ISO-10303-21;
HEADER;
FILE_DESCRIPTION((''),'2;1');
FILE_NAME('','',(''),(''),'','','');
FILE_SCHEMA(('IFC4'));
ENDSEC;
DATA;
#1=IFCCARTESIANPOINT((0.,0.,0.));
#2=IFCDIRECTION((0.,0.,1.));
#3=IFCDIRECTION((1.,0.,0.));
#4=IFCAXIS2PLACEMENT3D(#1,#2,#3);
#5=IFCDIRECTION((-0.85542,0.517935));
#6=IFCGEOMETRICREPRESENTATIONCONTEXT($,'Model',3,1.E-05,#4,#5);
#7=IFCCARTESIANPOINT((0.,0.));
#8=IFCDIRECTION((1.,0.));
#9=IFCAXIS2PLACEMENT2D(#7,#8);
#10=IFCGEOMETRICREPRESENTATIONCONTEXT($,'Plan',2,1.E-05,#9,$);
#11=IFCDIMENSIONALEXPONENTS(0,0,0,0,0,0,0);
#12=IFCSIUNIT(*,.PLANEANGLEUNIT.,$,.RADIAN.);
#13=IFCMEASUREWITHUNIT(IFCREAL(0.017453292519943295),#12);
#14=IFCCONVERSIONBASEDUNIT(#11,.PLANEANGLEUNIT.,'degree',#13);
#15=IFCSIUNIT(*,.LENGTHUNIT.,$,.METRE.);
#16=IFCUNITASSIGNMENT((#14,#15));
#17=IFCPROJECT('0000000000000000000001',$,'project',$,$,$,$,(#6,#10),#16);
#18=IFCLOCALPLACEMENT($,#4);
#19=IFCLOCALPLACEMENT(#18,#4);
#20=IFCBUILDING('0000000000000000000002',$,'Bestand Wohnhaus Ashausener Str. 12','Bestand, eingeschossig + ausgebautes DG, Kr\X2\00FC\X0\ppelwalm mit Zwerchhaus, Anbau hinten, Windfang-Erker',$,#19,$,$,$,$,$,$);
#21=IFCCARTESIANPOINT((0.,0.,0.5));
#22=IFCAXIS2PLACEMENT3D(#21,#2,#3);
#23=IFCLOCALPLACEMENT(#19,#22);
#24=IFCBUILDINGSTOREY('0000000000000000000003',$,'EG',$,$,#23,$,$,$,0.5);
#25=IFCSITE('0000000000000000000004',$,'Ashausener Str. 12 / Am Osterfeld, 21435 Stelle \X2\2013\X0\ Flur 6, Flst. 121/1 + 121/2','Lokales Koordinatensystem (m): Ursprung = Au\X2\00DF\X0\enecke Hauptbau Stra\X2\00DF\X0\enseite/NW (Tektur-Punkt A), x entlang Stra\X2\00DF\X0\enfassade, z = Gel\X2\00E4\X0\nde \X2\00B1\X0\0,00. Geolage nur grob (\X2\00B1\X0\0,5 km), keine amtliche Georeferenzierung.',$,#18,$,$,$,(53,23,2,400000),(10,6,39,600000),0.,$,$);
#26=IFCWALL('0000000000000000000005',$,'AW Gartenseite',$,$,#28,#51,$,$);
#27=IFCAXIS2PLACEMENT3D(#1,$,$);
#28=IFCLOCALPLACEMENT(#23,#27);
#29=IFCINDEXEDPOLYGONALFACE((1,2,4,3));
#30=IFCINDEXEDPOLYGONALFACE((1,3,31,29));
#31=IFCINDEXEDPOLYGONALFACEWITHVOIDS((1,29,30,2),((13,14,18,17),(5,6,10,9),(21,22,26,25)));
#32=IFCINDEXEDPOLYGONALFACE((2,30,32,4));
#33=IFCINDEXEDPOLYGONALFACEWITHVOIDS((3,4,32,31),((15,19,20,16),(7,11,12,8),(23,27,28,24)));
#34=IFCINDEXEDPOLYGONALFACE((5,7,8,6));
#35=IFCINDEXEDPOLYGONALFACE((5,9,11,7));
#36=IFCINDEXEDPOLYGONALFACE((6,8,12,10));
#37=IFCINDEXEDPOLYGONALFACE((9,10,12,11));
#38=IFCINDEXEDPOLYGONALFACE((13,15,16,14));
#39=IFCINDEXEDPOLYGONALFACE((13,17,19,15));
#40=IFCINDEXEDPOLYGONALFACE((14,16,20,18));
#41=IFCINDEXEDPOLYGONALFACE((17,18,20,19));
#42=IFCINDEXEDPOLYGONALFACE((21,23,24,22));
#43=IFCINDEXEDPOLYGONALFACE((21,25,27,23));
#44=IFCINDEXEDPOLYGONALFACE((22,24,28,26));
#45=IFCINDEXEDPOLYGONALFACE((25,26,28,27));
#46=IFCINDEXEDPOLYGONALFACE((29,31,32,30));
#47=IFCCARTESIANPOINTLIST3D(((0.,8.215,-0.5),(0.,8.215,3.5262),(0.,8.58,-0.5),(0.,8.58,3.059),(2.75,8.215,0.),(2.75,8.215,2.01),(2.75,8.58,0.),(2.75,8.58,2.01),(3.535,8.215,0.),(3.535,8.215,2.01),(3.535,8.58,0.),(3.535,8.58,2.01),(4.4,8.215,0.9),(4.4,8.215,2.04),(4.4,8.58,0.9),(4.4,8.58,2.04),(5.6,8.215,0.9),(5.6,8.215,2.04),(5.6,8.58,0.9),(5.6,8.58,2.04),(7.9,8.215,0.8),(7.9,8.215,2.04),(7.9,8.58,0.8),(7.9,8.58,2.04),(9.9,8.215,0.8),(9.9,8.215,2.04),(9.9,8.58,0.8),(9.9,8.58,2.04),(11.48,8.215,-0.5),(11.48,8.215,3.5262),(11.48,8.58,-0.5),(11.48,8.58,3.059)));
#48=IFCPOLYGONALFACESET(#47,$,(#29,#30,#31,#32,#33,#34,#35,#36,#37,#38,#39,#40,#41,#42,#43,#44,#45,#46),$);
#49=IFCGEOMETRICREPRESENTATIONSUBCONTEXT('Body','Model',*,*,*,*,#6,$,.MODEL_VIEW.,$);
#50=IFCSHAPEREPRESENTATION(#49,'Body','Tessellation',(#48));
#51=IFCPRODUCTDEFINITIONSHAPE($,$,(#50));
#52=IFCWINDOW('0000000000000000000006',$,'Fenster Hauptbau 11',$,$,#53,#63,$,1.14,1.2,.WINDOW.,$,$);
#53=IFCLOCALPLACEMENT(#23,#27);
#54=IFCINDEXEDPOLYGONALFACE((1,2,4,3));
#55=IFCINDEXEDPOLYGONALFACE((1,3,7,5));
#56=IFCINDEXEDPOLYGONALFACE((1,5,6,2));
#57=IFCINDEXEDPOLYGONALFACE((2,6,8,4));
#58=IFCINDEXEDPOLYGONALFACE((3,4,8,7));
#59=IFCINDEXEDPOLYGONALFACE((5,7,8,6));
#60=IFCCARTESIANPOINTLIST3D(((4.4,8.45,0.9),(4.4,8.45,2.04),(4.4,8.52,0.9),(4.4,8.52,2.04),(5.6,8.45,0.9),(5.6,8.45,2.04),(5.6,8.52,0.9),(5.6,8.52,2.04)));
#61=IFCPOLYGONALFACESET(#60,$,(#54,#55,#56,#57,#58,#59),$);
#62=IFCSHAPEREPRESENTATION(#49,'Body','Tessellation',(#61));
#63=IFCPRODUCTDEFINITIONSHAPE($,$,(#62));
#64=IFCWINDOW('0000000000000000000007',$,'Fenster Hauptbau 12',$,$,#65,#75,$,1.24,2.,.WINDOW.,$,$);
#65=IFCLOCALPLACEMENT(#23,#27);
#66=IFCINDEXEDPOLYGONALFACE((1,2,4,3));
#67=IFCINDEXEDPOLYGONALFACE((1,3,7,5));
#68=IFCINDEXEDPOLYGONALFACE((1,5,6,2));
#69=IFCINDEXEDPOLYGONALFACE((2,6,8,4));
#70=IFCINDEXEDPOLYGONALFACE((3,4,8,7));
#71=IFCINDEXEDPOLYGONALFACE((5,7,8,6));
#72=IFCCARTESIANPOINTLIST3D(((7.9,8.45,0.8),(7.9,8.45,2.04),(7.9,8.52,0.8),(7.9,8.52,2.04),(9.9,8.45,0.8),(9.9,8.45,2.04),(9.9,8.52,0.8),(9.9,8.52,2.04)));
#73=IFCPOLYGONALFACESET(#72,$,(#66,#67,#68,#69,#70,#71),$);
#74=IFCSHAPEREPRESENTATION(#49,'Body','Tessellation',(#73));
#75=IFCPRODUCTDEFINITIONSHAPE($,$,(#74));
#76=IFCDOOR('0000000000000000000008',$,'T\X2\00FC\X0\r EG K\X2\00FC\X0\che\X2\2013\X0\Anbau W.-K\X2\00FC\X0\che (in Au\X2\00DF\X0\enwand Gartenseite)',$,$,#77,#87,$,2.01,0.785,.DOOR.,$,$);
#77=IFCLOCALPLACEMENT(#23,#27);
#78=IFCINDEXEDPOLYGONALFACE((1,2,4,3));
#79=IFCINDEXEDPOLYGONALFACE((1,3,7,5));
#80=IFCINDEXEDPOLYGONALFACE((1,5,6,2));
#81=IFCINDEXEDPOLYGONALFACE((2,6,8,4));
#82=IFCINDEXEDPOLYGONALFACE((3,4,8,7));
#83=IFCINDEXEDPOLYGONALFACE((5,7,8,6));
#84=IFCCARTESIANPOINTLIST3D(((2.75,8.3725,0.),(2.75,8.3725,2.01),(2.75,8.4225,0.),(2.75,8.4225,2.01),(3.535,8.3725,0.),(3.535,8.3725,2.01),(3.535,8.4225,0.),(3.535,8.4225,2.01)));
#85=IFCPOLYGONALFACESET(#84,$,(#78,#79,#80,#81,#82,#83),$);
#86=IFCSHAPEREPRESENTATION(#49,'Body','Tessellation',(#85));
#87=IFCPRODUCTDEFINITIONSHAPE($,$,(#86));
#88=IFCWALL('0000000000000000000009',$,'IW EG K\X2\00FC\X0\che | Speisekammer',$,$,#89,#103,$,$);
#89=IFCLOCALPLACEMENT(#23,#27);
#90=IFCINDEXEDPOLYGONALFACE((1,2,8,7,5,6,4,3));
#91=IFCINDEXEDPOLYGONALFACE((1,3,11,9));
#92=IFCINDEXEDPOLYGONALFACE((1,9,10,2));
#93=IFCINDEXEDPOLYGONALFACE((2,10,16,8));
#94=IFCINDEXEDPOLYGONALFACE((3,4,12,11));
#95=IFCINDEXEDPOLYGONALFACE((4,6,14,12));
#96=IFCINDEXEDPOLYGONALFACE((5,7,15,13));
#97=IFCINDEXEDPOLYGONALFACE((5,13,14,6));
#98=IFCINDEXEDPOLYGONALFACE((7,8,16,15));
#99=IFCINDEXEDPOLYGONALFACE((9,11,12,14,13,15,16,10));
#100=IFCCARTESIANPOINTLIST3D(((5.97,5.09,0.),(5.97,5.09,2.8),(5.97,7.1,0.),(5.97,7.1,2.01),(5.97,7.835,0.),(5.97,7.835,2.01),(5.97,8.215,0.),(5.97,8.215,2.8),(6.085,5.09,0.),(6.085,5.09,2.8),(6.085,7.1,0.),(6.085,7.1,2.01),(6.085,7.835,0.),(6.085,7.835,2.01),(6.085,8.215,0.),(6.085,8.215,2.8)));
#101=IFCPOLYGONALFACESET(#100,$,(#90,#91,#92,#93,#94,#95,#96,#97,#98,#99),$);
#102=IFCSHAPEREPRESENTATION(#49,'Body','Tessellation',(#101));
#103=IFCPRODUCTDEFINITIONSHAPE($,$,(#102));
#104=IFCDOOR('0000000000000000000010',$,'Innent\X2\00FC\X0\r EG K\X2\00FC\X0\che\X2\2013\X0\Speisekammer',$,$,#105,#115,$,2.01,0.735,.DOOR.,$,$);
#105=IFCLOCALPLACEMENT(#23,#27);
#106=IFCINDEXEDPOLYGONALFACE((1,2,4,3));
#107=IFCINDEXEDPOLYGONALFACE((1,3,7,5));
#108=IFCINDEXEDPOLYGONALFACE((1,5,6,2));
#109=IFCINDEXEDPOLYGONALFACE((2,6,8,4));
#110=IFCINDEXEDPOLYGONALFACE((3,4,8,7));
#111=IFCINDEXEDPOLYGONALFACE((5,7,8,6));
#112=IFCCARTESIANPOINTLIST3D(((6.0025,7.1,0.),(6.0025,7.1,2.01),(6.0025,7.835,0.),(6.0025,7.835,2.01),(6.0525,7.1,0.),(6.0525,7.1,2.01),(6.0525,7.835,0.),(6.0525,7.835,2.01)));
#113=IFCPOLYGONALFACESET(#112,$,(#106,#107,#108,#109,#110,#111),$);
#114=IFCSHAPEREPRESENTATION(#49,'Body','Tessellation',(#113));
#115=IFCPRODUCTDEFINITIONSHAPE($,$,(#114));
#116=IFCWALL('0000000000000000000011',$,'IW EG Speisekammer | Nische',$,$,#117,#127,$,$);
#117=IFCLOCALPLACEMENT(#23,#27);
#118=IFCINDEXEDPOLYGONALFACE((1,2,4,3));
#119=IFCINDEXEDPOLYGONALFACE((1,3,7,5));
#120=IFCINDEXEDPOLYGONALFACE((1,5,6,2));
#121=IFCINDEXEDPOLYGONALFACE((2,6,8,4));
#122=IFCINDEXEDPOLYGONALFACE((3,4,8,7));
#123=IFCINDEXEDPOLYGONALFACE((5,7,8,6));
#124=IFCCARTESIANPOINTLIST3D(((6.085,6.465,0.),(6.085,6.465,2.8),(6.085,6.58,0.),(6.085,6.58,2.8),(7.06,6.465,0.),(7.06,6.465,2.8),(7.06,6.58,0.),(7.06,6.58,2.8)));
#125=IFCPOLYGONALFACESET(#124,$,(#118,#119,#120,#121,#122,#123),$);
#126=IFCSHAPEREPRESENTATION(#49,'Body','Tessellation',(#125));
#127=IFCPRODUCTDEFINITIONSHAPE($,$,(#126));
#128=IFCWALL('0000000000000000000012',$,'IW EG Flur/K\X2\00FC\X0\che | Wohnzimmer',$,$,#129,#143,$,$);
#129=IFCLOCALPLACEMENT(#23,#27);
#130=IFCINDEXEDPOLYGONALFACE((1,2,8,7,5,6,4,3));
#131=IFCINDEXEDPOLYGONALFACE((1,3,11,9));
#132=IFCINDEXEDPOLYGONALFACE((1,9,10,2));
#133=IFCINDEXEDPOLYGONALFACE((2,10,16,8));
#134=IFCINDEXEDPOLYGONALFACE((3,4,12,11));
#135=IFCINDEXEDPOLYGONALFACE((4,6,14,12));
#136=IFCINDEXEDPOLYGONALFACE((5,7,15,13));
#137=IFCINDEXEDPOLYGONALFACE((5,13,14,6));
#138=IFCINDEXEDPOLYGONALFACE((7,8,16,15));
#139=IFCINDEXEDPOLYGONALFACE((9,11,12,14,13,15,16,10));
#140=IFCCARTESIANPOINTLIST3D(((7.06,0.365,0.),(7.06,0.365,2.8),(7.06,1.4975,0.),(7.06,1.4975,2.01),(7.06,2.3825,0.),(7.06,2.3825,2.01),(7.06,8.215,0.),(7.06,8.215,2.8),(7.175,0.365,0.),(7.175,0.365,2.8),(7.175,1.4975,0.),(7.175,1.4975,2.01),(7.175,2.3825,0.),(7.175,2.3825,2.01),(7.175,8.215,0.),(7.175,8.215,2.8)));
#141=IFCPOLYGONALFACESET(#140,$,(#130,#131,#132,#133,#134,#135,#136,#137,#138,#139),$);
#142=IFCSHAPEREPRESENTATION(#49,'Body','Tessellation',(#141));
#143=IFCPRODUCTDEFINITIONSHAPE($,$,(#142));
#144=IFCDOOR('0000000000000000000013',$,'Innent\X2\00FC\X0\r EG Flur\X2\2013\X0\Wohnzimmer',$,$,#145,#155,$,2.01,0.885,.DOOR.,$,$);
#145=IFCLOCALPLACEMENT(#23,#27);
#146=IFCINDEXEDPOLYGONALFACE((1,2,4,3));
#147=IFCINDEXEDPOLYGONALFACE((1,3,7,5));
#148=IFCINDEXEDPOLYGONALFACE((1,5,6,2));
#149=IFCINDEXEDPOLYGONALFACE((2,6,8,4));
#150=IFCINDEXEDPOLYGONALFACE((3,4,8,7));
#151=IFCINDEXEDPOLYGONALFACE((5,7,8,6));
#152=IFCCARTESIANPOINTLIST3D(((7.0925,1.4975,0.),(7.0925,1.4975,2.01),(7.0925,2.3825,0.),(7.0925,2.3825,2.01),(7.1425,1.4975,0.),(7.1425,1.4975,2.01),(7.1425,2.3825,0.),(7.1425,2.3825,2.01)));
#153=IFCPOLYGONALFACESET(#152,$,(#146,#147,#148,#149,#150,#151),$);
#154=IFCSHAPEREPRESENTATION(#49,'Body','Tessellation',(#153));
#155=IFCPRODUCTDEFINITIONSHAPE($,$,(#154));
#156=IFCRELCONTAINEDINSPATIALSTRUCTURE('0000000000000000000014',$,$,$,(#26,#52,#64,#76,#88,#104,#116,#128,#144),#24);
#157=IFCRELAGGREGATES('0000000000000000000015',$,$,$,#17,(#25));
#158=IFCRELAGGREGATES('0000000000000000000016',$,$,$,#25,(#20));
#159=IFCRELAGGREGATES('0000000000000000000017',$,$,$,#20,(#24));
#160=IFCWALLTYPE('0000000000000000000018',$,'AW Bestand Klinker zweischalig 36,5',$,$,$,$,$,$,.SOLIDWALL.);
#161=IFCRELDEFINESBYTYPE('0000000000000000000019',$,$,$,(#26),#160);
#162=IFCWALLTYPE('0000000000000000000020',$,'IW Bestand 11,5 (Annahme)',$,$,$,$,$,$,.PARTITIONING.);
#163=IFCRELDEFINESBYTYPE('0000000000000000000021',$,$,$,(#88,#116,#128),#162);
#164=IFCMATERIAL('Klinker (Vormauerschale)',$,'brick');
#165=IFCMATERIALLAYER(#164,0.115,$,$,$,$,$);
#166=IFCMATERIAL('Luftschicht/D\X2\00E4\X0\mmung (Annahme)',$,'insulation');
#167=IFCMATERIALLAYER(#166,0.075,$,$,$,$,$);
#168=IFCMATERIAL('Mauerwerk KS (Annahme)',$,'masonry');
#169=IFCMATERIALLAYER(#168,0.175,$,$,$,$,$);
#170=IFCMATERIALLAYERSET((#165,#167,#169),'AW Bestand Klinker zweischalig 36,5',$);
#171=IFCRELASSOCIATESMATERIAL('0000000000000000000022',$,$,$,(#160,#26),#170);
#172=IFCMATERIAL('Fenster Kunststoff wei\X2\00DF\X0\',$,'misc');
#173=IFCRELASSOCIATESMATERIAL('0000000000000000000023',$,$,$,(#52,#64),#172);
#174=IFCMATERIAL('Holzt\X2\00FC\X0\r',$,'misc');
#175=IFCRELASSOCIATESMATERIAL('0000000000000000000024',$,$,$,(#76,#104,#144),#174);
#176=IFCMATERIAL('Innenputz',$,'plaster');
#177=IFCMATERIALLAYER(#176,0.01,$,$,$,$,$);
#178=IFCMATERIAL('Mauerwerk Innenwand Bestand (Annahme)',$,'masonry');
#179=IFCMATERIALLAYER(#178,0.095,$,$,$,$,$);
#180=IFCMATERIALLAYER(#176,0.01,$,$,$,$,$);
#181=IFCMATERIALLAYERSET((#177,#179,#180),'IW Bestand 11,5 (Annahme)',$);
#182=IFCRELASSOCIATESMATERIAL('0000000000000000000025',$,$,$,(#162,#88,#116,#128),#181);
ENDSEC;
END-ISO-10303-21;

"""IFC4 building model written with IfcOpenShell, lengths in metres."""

from ifc_helpers import new_model, entity, si_unit, converted_unit, direction, frame, origin_with_axes, origin_2d_with_axis, place, context, subcontext, project, spatial, indexed_curve, outline, extrude, clip, halfspace, material, layer, layer_set, layer_usage, type_object, element, fill, save


model = new_model("IFC4")

# Units and contexts
model_context = context("Model", 3, precision=1e-05, world=origin_with_axes(), true_north=direction((-0.85542, 0.517935)))
plan_context = context("Plan", 2, precision=1e-05, world=origin_2d_with_axis())
body_context = subcontext(model_context, "Body", "Model", "MODEL_VIEW")
ifc_project = project(units=[converted_unit("PLANEANGLEUNIT", "degree", entity("IfcReal", 0.017453292519943295), si_unit("PLANEANGLEUNIT", "RADIAN"), dimensions=[0, 0, 0, 0, 0, 0, 0]), si_unit("LENGTHUNIT", "METRE")], contexts=[model_context, plan_context])

# Site, building, storey
site_placement = place(None, origin_with_axes())
site = spatial("IfcSite", under=ifc_project, at=site_placement, Name="Ashausener Str. 12 / Am Osterfeld, 21435 Stelle – Flur 6, Flst. 121/1 + 121/2", Description="Lokales Koordinatensystem (m): Ursprung = Außenecke Hauptbau Straßenseite/NW (Tektur-Punkt A), x entlang Straßenfassade, z = Gelände ±0,00. Geolage nur grob (±0,5 km), keine amtliche Georeferenzierung.", RefLatitude=(53, 23, 2, 400000), RefLongitude=(10, 6, 39, 600000), RefElevation=0.0)
building_placement = place(site_placement, origin_with_axes())
building = spatial("IfcBuilding", under=site, at=building_placement, Name="Bestand Wohnhaus Ashausener Str. 12", Description="Bestand, eingeschossig + ausgebautes DG, Krüppelwalm mit Zwerchhaus, Anbau hinten, Windfang-Erker")
storey_placement = place(building_placement, frame((0.0, 0.0, 0.5), z_axis=(0.0, 0.0, 1.0), x_axis=(1.0, 0.0, 0.0)))
storey = spatial("IfcBuildingStorey", under=building, at=storey_placement, Name="EG", Elevation=0.5)

# Wall, openings, windows, door
ifc_material_1 = material(Name="Klinker (Vormauerschale)", Category="brick")
ifc_layer_1 = layer(ifc_material_1, 0.115)
ifc_material_2 = material(Name="Luftschicht/Dämmung (Annahme)", Category="insulation")
ifc_layer_2 = layer(ifc_material_2, 0.075)
ifc_material_3 = material(Name="Mauerwerk KS (Annahme)", Category="masonry")
ifc_layer_3 = layer(ifc_material_3, 0.175)
ifc_layer_set_1 = layer_set([ifc_layer_1, ifc_layer_2, ifc_layer_3], Name="AW Bestand Klinker zweischalig 36,5")
ifc_layer_usage_1 = layer_usage(ifc_layer_set_1, "AXIS2", "POSITIVE", 0.0)
wall_type_1 = type_object("IfcWallType", Name="AW Bestand Klinker zweischalig 36,5", PredefinedType="SOLIDWALL", material=ifc_layer_set_1)
wall_1_placement = place(storey_placement, frame((11.48, 8.58, -0.5), z_axis=(0.0, 0.0, 1.0), x_axis=(-1.0, 0.0, 0.0)))
wall_1 = element("IfcWall", 1, at=wall_1_placement, inside=storey, type_object=wall_type_1, material=ifc_layer_usage_1, Name="AW Gartenseite", context=body_context, shape_type="Clipping", body=[
    clip(clip(clip(clip(extrude(outline(indexed_curve([(0.0, 0.0), (0.0, 0.365), (11.48, 0.365), (11.48, 0.0), (0.0, 0.0)], self_intersect=False)), origin_with_axes(), (0.0, 0.0, 1.0), 12.0), halfspace(frame((-0.39, 8.58, 5.9), z_axis=(-0.76604, 0.0, 0.64279), x_axis=(0.0, 1.0, 0.0)), False)), halfspace(frame((11.87, 8.58, 5.9), z_axis=(0.76604, 0.0, 0.64279), x_axis=(0.0, -1.0, 0.0)), False)), halfspace(frame((11.48, 4.29, 9.05), z_axis=(0.0, -0.78801, 0.61566), x_axis=(-1.0, 0.0, 0.0)), False)), halfspace(frame((11.48, 4.29, 9.05), z_axis=(0.0, 0.78801, 0.61566), x_axis=(1.0, 0.0, 0.0)), False)),
])
opening_1_placement = place(wall_1_placement, frame((5.88, -0.1, 1.4), z_axis=(0.0, 0.0, 1.0), x_axis=(1.0, 0.0, 0.0)))
opening_1 = element("IfcOpeningElement", 2, at=opening_1_placement, cuts=wall_1, context=body_context, shape_type="SweptSolid", body=[
    extrude(outline(indexed_curve([(0.0, 0.0), (0.0, 0.565), (1.2, 0.565), (1.2, 0.0), (0.0, 0.0)], self_intersect=False)), origin_with_axes(), (0.0, 0.0, 1.0), 1.14),
])
opening_2_placement = place(wall_1_placement, frame((1.58, -0.1, 1.3), z_axis=(0.0, 0.0, 1.0), x_axis=(1.0, 0.0, 0.0)))
opening_2 = element("IfcOpeningElement", 3, at=opening_2_placement, cuts=wall_1, context=body_context, shape_type="SweptSolid", body=[
    extrude(outline(indexed_curve([(0.0, 0.0), (0.0, 0.565), (2.0, 0.565), (2.0, 0.0), (0.0, 0.0)], self_intersect=False)), origin_with_axes(), (0.0, 0.0, 1.0), 1.24),
])
opening_3_placement = place(wall_1_placement, frame((7.945, -0.1, 0.5), z_axis=(0.0, 0.0, 1.0), x_axis=(1.0, 0.0, 0.0)))
opening_3 = element("IfcOpeningElement", 4, at=opening_3_placement, cuts=wall_1, context=body_context, shape_type="SweptSolid", body=[
    extrude(outline(indexed_curve([(0.0, 0.0), (0.0, 0.565), (0.785, 0.565), (0.785, 0.0), (0.0, 0.0)], self_intersect=False)), origin_with_axes(), (0.0, 0.0, 1.0), 2.01),
])
ifc_material_4 = material(Name="Fenster Kunststoff weiß", Category="misc")
window_1_placement = place(storey_placement, frame((5.6, 8.52, 0.9), z_axis=(0.0, 0.0, 1.0), x_axis=(-1.0, 0.0, 0.0)))
window_1 = element("IfcWindow", 5, at=window_1_placement, inside=storey, material=ifc_material_4, Name="Fenster Hauptbau 11", OverallHeight=1.14, OverallWidth=1.2, PredefinedType="WINDOW", context=body_context, shape_type="SweptSolid", body=[
    extrude(outline(indexed_curve([(0.0, 0.0), (0.0, 0.07), (1.2, 0.07), (1.2, 0.0), (0.0, 0.0)], self_intersect=False)), origin_with_axes(), (0.0, 0.0, 1.0), 1.14),
])
fill(opening_1, window_1)
window_2_placement = place(storey_placement, frame((9.9, 8.52, 0.8), z_axis=(0.0, 0.0, 1.0), x_axis=(-1.0, 0.0, 0.0)))
window_2 = element("IfcWindow", 6, at=window_2_placement, inside=storey, material=ifc_material_4, Name="Fenster Hauptbau 12", OverallHeight=1.24, OverallWidth=2.0, PredefinedType="WINDOW", context=body_context, shape_type="SweptSolid", body=[
    extrude(outline(indexed_curve([(0.0, 0.0), (0.0, 0.07), (2.0, 0.07), (2.0, 0.0), (0.0, 0.0)], self_intersect=False)), origin_with_axes(), (0.0, 0.0, 1.0), 1.24),
])
fill(opening_2, window_2)
ifc_material_5 = material(Name="Holztür", Category="misc")
door_1_placement = place(storey_placement, frame((3.535, 8.4225, 0.0), z_axis=(0.0, 0.0, 1.0), x_axis=(-1.0, 0.0, 0.0)))
door_1 = element("IfcDoor", 7, at=door_1_placement, inside=storey, material=ifc_material_5, Name="Tür EG Küche–Anbau W.-Küche (in Außenwand Gartenseite)", OverallHeight=2.01, OverallWidth=0.785, PredefinedType="DOOR", context=body_context, shape_type="SweptSolid", body=[
    extrude(outline(indexed_curve([(0.0, 0.0), (0.0, 0.05), (0.785, 0.05), (0.785, 0.0), (0.0, 0.0)], self_intersect=False)), origin_with_axes(), (0.0, 0.0, 1.0), 2.01),
])
fill(opening_3, door_1)

# Wall, opening, door
ifc_material_6 = material(Name="Innenputz", Category="plaster")
ifc_layer_4 = layer(ifc_material_6, 0.01)
ifc_material_7 = material(Name="Mauerwerk Innenwand Bestand (Annahme)", Category="masonry")
ifc_layer_5 = layer(ifc_material_7, 0.095)
ifc_layer_6 = layer(ifc_material_6, 0.01)
ifc_layer_set_2 = layer_set([ifc_layer_4, ifc_layer_5, ifc_layer_6], Name="IW Bestand 11,5 (Annahme)")
ifc_layer_usage_2 = layer_usage(ifc_layer_set_2, "AXIS2", "POSITIVE", 0.0)
wall_type_2 = type_object("IfcWallType", Name="IW Bestand 11,5 (Annahme)", PredefinedType="PARTITIONING", material=ifc_layer_set_2)
wall_2_placement = place(storey_placement, frame((5.97, 8.215, 0.0), z_axis=(0.0, 0.0, 1.0), x_axis=(0.0, -1.0, 0.0)))
wall_2 = element("IfcWall", 8, at=wall_2_placement, inside=storey, type_object=wall_type_2, material=ifc_layer_usage_2, Name="IW EG Küche | Speisekammer", context=body_context, shape_type="SweptSolid", body=[
    extrude(outline(indexed_curve([(0.0, 0.0), (0.0, 0.115), (3.125, 0.115), (3.125, 0.0), (0.0, 0.0)], self_intersect=False)), origin_with_axes(), (0.0, 0.0, 1.0), 2.8),
])
opening_4_placement = place(wall_2_placement, frame((0.38, -0.1, 0.0), z_axis=(0.0, 0.0, 1.0), x_axis=(1.0, 0.0, 0.0)))
opening_4 = element("IfcOpeningElement", 9, at=opening_4_placement, cuts=wall_2, context=body_context, shape_type="SweptSolid", body=[
    extrude(outline(indexed_curve([(0.0, 0.0), (0.0, 0.315), (0.735, 0.315), (0.735, 0.0), (0.0, 0.0)], self_intersect=False)), origin_with_axes(), (0.0, 0.0, 1.0), 2.01),
])
door_2_placement = place(storey_placement, frame((6.0025, 7.835, 0.0), z_axis=(0.0, 0.0, 1.0), x_axis=(0.0, -1.0, 0.0)))
door_2 = element("IfcDoor", 10, at=door_2_placement, inside=storey, material=ifc_material_5, Name="Innentür EG Küche–Speisekammer", OverallHeight=2.01, OverallWidth=0.735, PredefinedType="DOOR", context=body_context, shape_type="SweptSolid", body=[
    extrude(outline(indexed_curve([(0.0, 0.0), (0.0, 0.05), (0.735, 0.05), (0.735, 0.0), (0.0, 0.0)], self_intersect=False)), origin_with_axes(), (0.0, 0.0, 1.0), 2.01),
])
fill(opening_4, door_2)

# Wall
ifc_layer_usage_3 = layer_usage(ifc_layer_set_2, "AXIS2", "POSITIVE", 0.0)
wall_3_placement = place(storey_placement, frame((6.085, 6.465, 0.0), z_axis=(0.0, 0.0, 1.0), x_axis=(1.0, 0.0, 0.0)))
element("IfcWall", 11, at=wall_3_placement, inside=storey, type_object=wall_type_2, material=ifc_layer_usage_3, Name="IW EG Speisekammer | Nische", context=body_context, shape_type="SweptSolid", body=[
    extrude(outline(indexed_curve([(0.0, 0.0), (0.0, 0.115), (0.975, 0.115), (0.975, 0.0), (0.0, 0.0)], self_intersect=False)), origin_with_axes(), (0.0, 0.0, 1.0), 2.8),
])

# Wall, opening, door
ifc_layer_usage_4 = layer_usage(ifc_layer_set_2, "AXIS2", "POSITIVE", 0.0)
wall_4_placement = place(storey_placement, frame((7.06, 8.215, 0.0), z_axis=(0.0, 0.0, 1.0), x_axis=(0.0, -1.0, 0.0)))
wall_4 = element("IfcWall", 12, at=wall_4_placement, inside=storey, type_object=wall_type_2, material=ifc_layer_usage_4, Name="IW EG Flur/Küche | Wohnzimmer", context=body_context, shape_type="SweptSolid", body=[
    extrude(outline(indexed_curve([(0.0, 0.0), (0.0, 0.115), (7.85, 0.115), (7.85, 0.0), (0.0, 0.0)], self_intersect=False)), origin_with_axes(), (0.0, 0.0, 1.0), 2.8),
])
opening_5_placement = place(wall_4_placement, frame((5.8325, -0.1, 0.0), z_axis=(0.0, 0.0, 1.0), x_axis=(1.0, 0.0, 0.0)))
opening_5 = element("IfcOpeningElement", 13, at=opening_5_placement, cuts=wall_4, context=body_context, shape_type="SweptSolid", body=[
    extrude(outline(indexed_curve([(0.0, 0.0), (0.0, 0.315), (0.885, 0.315), (0.885, 0.0), (0.0, 0.0)], self_intersect=False)), origin_with_axes(), (0.0, 0.0, 1.0), 2.01),
])
door_3_placement = place(storey_placement, frame((7.0925, 2.3825, 0.0), z_axis=(0.0, 0.0, 1.0), x_axis=(0.0, -1.0, 0.0)))
door_3 = element("IfcDoor", 14, at=door_3_placement, inside=storey, material=ifc_material_5, Name="Innentür EG Flur–Wohnzimmer", OverallHeight=2.01, OverallWidth=0.885, PredefinedType="DOOR", context=body_context, shape_type="SweptSolid", body=[
    extrude(outline(indexed_curve([(0.0, 0.0), (0.0, 0.05), (0.885, 0.05), (0.885, 0.0), (0.0, 0.0)], self_intersect=False)), origin_with_axes(), (0.0, 0.0, 1.0), 2.01),
])
fill(opening_5, door_3)

save(model, "model.ifc")
